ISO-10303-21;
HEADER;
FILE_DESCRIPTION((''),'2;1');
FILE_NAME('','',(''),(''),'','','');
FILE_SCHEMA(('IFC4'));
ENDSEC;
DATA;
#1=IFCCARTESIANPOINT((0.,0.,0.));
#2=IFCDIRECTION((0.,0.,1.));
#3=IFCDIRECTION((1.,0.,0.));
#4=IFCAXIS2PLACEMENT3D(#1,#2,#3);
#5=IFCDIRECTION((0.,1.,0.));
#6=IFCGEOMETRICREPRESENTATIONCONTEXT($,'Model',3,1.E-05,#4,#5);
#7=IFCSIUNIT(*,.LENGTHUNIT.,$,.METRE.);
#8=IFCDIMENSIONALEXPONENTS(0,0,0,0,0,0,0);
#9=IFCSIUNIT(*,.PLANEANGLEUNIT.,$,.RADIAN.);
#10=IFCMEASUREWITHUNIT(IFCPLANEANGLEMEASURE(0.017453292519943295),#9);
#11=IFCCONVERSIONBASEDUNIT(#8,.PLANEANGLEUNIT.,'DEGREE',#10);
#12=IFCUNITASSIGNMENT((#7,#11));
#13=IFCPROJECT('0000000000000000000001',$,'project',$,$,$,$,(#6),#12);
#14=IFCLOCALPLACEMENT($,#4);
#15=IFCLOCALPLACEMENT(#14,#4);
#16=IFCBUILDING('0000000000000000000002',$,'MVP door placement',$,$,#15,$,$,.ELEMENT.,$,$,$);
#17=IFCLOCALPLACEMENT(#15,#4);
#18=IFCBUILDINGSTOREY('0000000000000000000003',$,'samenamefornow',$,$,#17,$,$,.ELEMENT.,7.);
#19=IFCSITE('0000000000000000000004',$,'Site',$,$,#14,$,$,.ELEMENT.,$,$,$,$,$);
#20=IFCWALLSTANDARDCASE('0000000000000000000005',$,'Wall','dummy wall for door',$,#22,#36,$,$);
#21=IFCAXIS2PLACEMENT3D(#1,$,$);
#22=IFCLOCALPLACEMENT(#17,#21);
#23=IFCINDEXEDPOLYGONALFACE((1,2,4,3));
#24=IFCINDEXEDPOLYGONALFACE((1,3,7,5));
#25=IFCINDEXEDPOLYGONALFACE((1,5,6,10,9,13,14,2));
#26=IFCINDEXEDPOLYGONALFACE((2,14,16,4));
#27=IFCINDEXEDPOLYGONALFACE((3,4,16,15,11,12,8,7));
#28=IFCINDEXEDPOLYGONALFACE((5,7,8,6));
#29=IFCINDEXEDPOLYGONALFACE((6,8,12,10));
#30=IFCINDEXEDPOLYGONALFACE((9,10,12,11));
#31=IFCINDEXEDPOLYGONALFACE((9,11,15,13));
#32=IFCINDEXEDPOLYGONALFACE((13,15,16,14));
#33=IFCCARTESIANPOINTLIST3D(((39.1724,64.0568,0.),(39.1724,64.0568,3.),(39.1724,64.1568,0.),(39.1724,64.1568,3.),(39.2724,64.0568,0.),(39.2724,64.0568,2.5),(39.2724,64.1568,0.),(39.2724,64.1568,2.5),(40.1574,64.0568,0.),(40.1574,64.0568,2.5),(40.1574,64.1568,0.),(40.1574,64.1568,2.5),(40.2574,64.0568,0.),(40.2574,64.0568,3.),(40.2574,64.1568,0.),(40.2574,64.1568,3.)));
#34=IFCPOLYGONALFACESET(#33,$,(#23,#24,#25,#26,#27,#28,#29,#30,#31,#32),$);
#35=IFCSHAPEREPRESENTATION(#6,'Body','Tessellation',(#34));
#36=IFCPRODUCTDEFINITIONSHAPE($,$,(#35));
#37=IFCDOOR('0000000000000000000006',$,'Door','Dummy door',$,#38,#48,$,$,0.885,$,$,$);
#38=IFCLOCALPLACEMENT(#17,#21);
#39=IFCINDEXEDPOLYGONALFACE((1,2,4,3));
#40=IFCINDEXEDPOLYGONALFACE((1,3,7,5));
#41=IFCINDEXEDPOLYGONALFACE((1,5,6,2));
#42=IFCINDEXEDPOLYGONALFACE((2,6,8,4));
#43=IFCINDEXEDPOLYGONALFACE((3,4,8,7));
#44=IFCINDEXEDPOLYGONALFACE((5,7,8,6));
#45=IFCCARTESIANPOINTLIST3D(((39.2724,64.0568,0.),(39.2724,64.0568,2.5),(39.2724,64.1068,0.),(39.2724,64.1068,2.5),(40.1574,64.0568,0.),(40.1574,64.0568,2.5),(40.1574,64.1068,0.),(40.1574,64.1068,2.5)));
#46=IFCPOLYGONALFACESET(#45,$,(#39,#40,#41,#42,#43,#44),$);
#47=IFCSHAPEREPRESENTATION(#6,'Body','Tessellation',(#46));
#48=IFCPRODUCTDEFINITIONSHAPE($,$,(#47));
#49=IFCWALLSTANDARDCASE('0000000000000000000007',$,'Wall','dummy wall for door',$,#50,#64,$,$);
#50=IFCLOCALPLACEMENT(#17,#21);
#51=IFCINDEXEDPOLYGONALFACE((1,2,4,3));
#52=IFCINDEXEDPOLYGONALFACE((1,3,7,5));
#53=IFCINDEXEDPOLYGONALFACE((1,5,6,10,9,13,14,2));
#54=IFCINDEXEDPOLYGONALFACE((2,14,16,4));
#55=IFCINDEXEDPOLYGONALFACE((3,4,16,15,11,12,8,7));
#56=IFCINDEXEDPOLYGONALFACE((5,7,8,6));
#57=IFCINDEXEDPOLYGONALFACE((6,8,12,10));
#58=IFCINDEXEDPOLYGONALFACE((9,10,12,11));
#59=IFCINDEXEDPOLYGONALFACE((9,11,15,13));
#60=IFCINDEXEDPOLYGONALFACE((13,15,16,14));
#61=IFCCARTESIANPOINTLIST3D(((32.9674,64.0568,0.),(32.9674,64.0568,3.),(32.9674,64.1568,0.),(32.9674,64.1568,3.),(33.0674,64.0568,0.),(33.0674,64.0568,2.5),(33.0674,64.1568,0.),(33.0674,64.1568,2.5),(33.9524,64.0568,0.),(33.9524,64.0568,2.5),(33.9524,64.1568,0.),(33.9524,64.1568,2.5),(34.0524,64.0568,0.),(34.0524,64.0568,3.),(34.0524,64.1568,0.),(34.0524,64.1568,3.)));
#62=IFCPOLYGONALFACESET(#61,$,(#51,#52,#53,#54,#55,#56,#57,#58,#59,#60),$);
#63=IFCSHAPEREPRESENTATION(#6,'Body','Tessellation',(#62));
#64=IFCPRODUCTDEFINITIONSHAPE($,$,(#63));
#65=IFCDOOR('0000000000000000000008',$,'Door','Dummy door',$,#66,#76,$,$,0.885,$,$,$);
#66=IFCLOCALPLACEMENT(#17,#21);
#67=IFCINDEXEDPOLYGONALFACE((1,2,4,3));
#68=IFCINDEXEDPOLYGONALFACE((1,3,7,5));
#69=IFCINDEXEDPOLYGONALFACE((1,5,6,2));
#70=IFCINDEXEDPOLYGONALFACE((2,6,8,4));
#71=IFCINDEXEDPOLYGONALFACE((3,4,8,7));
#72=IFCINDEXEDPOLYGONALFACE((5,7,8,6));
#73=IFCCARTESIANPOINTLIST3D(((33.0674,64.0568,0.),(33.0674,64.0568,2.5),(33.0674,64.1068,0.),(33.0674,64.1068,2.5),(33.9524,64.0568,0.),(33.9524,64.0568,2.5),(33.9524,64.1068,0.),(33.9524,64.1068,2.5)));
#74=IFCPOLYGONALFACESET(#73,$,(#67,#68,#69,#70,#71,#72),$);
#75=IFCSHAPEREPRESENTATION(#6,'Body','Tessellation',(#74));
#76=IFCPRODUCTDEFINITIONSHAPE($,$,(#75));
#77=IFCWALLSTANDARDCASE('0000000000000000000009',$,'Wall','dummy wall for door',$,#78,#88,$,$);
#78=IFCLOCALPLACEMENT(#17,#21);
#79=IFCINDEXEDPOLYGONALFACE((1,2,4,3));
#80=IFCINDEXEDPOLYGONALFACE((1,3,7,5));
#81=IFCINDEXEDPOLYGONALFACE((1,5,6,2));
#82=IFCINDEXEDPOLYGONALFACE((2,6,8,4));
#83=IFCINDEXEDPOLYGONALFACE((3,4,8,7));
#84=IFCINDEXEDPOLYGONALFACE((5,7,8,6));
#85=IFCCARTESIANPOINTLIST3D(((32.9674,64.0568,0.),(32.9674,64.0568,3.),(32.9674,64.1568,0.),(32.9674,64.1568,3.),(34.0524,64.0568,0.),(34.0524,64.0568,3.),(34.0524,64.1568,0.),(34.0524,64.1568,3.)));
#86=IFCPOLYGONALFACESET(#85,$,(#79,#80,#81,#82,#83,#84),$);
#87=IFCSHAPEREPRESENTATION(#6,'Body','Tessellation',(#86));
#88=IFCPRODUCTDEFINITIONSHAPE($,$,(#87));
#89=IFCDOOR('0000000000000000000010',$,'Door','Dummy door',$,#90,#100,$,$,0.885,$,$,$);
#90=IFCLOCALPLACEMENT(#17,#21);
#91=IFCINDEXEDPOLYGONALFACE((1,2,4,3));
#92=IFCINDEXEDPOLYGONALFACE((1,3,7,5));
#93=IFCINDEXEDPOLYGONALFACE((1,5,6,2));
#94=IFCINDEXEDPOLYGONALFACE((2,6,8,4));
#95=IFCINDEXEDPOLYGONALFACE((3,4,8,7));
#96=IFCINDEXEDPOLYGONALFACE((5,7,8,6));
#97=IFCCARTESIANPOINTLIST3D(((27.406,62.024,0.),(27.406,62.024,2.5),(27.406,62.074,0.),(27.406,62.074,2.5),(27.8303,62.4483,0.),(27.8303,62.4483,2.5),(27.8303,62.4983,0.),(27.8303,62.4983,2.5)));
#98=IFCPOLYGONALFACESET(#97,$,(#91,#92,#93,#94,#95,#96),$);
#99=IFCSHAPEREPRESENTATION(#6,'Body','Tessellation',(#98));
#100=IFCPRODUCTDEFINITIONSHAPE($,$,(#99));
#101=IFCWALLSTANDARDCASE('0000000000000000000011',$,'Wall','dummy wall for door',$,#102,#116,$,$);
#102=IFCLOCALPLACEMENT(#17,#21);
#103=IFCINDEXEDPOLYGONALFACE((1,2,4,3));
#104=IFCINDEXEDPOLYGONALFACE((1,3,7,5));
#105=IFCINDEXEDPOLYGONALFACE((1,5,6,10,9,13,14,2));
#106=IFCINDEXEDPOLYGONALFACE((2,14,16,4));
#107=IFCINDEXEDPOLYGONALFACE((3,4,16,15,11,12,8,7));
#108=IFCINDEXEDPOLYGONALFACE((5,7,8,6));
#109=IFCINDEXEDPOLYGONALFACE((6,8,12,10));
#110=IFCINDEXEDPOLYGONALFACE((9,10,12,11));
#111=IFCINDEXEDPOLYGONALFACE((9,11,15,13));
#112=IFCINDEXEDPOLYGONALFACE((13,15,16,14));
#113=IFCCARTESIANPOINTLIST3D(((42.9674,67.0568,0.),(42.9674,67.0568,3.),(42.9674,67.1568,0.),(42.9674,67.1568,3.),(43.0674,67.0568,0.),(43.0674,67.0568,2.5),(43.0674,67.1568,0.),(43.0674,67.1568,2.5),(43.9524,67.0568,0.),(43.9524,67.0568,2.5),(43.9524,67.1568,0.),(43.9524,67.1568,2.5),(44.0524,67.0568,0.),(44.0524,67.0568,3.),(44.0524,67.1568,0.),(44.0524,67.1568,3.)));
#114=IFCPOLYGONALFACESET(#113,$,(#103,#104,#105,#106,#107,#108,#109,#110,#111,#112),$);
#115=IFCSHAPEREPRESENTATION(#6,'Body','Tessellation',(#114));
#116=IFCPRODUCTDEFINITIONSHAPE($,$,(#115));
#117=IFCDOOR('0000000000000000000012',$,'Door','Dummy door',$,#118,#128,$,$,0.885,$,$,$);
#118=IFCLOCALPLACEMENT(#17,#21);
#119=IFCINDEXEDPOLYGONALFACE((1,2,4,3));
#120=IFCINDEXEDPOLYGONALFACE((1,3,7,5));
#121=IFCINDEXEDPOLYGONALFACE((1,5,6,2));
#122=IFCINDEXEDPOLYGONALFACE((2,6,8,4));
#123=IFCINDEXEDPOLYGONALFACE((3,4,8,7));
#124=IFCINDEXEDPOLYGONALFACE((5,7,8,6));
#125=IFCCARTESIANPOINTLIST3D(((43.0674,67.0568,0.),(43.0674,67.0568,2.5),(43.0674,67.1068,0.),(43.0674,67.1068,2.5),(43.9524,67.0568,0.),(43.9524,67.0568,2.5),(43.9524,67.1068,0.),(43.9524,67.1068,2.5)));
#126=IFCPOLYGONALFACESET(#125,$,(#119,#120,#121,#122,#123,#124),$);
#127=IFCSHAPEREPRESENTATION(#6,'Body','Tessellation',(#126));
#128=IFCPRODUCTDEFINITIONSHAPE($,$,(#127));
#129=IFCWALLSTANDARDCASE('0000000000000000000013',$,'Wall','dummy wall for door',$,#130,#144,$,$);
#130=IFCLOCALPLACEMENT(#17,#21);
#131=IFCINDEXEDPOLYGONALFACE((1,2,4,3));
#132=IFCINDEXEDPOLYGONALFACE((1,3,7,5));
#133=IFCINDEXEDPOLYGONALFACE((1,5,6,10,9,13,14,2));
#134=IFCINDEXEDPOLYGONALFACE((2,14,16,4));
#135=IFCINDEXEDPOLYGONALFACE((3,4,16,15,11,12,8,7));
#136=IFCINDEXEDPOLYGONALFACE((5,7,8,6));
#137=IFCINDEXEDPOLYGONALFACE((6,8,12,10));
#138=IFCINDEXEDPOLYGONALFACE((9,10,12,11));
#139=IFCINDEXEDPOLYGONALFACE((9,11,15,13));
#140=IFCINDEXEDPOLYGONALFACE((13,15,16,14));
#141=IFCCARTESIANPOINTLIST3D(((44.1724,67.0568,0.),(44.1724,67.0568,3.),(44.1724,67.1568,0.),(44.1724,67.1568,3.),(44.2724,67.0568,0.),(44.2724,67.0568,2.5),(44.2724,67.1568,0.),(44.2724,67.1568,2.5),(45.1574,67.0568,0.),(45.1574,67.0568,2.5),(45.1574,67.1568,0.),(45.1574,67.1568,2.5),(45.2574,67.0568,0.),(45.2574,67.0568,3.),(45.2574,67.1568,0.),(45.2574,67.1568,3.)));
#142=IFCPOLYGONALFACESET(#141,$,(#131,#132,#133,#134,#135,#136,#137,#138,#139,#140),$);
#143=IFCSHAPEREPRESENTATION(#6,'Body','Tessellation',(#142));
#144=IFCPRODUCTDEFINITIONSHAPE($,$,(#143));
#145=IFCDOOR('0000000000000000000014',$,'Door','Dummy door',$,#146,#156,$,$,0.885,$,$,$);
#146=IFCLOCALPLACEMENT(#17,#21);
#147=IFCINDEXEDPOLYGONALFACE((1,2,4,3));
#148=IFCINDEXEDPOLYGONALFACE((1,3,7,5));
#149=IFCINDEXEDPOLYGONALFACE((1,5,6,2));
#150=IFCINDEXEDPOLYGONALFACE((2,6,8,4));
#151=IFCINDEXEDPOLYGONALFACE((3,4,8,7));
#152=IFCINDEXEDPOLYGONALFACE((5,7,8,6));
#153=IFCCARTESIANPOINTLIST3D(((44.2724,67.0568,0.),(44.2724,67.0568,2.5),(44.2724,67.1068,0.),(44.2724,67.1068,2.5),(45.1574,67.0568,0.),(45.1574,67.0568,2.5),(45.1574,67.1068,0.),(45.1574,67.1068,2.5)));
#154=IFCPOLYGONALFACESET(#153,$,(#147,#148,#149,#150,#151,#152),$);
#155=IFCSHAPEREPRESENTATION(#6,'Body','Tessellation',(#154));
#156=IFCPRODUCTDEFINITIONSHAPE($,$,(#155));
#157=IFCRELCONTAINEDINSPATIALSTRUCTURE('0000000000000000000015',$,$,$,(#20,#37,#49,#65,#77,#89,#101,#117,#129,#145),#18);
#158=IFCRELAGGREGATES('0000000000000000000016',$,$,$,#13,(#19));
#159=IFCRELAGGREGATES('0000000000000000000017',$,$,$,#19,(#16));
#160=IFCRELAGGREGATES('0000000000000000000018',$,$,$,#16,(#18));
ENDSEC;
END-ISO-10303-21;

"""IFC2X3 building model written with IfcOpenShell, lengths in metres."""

from ifc_helpers import new_model, entity, si_unit, converted_unit, direction, origin_with_axes, place, context, project, spatial, polyline, outline, extrude, element, fill, save


model = new_model("IFC2X3")

# Units and contexts
model_context = context("Model", 3, precision=1e-05, world=origin_with_axes(), true_north=direction((0.0, 1.0, 0.0)))
ifc_project = project(units=[si_unit("LENGTHUNIT", "METRE"), converted_unit("PLANEANGLEUNIT", "DEGREE", entity("IfcPlaneAngleMeasure", 0.017453292519943295), si_unit("PLANEANGLEUNIT", "RADIAN"), dimensions=[0, 0, 0, 0, 0, 0, 0])], contexts=[model_context])

# Site, building, storey
site_placement = place(None, origin_with_axes())
site = spatial("IfcSite", under=ifc_project, at=site_placement, Name="Site", CompositionType="ELEMENT")
building_placement = place(site_placement, origin_with_axes())
building = spatial("IfcBuilding", under=site, at=building_placement, Name="MVP door placement", CompositionType="ELEMENT")
storey_placement = place(building_placement, origin_with_axes())
storey = spatial("IfcBuildingStorey", under=building, at=storey_placement, Name="samenamefornow", CompositionType="ELEMENT", Elevation=7.0)

# Walls, openings, doors
wall_1_placement = place(storey_placement, origin_with_axes())
wall_1 = element("IfcWallStandardCase", 1, at=wall_1_placement, inside=storey, Name="Wall", Description="dummy wall for door", context=model_context, shape_type="SweptSolid", body=[
    extrude(outline(polyline([(40.2574, 64.0568, 0.0), (39.1724, 64.0568, 0.0), (39.1724, 64.1568, 0.0), (40.2574, 64.1568, 0.0), (40.2574, 64.0568, 0.0)])), origin_with_axes(), (0.0, 0.0, 1.0), 3.0),
])
opening_1_placement = place(wall_1_placement, origin_with_axes())
opening_1 = element("IfcOpeningElement", 2, at=opening_1_placement, cuts=wall_1, context=model_context, shape_type="SweptSolid", body=[
    extrude(outline(polyline([(40.1574, 64.0568, 0.0), (39.2724, 64.0568, 0.0), (39.2724, 64.1568, 0.0), (40.1574, 64.1568, 0.0), (40.1574, 64.0568, 0.0)])), origin_with_axes(), (0.0, 0.0, 1.0), 2.5),
])
door_1_placement = place(opening_1_placement, origin_with_axes())
door_1 = element("IfcDoor", 3, at=door_1_placement, inside=storey, Name="Door", Description="Dummy door", OverallWidth=0.885, context=model_context, shape_type="SweptSolid", body=[
    extrude(outline(polyline([(40.1574, 64.0568, 0.0), (39.2724, 64.0568, 0.0), (39.2724, 64.1068, 0.0), (40.1574, 64.1068, 0.0), (40.1574, 64.0568, 0.0)])), origin_with_axes(), (0.0, 0.0, 1.0), 2.5),
])
fill(opening_1, door_1)
wall_2_placement = place(storey_placement, origin_with_axes())
wall_2 = element("IfcWallStandardCase", 4, at=wall_2_placement, inside=storey, Name="Wall", Description="dummy wall for door", context=model_context, shape_type="SweptSolid", body=[
    extrude(outline(polyline([(32.9674, 64.0568, 0.0), (34.0524, 64.0568, 0.0), (34.0524, 64.1568, 0.0), (32.9674, 64.1568, 0.0), (32.9674, 64.0568, 0.0)])), origin_with_axes(), (0.0, 0.0, 1.0), 3.0),
])
opening_2_placement = place(wall_2_placement, origin_with_axes())
opening_2 = element("IfcOpeningElement", 5, at=opening_2_placement, cuts=wall_2, context=model_context, shape_type="SweptSolid", body=[
    extrude(outline(polyline([(33.0674, 64.0568, 0.0), (33.9524, 64.0568, 0.0), (33.9524, 64.1568, 0.0), (33.0674, 64.1568, 0.0), (33.0674, 64.0568, 0.0)])), origin_with_axes(), (0.0, 0.0, 1.0), 2.5),
])
door_2_placement = place(opening_2_placement, origin_with_axes())
door_2 = element("IfcDoor", 6, at=door_2_placement, inside=storey, Name="Door", Description="Dummy door", OverallWidth=0.885, context=model_context, shape_type="SweptSolid", body=[
    extrude(outline(polyline([(33.0674, 64.0568, 0.0), (33.9524, 64.0568, 0.0), (33.9524, 64.1068, 0.0), (33.0674, 64.1068, 0.0), (33.0674, 64.0568, 0.0)])), origin_with_axes(), (0.0, 0.0, 1.0), 2.5),
])
fill(opening_2, door_2)
wall_3_placement = place(storey_placement, origin_with_axes())
wall_3 = element("IfcWallStandardCase", 7, at=wall_3_placement, inside=storey, Name="Wall", Description="dummy wall for door", context=model_context, shape_type="SweptSolid", body=[
    extrude(outline(polyline([(32.9674, 64.0568, 0.0), (34.0524, 64.0568, 0.0), (34.0524, 64.1568, 0.0), (32.9674, 64.1568, 0.0), (32.9674, 64.0568, 0.0)])), origin_with_axes(), (0.0, 0.0, 1.0), 3.0),
])
opening_3_placement = place(wall_3_placement, origin_with_axes())
opening_3 = element("IfcOpeningElement", 8, at=opening_3_placement, cuts=wall_3, context=model_context, shape_type="SweptSolid", body=[
    extrude(outline(polyline([(27.406, 62.024, 0.0), (27.8303, 62.4483, 0.0), (27.8303, 62.5483, 0.0), (27.406, 62.124, 0.0), (27.406, 62.024, 0.0)])), origin_with_axes(), (0.0, 0.0, 1.0), 2.5),
])
door_3_placement = place(opening_3_placement, origin_with_axes())
door_3 = element("IfcDoor", 9, at=door_3_placement, inside=storey, Name="Door", Description="Dummy door", OverallWidth=0.885, context=model_context, shape_type="SweptSolid", body=[
    extrude(outline(polyline([(27.406, 62.024, 0.0), (27.8303, 62.4483, 0.0), (27.8303, 62.4983, 0.0), (27.406, 62.074, 0.0), (27.406, 62.024, 0.0)])), origin_with_axes(), (0.0, 0.0, 1.0), 2.5),
])
fill(opening_3, door_3)
wall_4_placement = place(storey_placement, origin_with_axes())
wall_4 = element("IfcWallStandardCase", 10, at=wall_4_placement, inside=storey, Name="Wall", Description="dummy wall for door", context=model_context, shape_type="SweptSolid", body=[
    extrude(outline(polyline([(42.9674, 67.0568, 0.0), (44.0524, 67.0568, 0.0), (44.0524, 67.1568, 0.0), (42.9674, 67.1568, 0.0), (42.9674, 67.0568, 0.0)])), origin_with_axes(), (0.0, 0.0, 1.0), 3.0),
])
opening_4_placement = place(wall_4_placement, origin_with_axes())
opening_4 = element("IfcOpeningElement", 11, at=opening_4_placement, cuts=wall_4, context=model_context, shape_type="SweptSolid", body=[
    extrude(outline(polyline([(43.0674, 67.0568, 0.0), (43.9524, 67.0568, 0.0), (43.9524, 67.1568, 0.0), (43.0674, 67.1568, 0.0), (43.0674, 67.0568, 0.0)])), origin_with_axes(), (0.0, 0.0, 1.0), 2.5),
])
door_4_placement = place(opening_4_placement, origin_with_axes())
door_4 = element("IfcDoor", 12, at=door_4_placement, inside=storey, Name="Door", Description="Dummy door", OverallWidth=0.885, context=model_context, shape_type="SweptSolid", body=[
    extrude(outline(polyline([(43.0674, 67.0568, 0.0), (43.9524, 67.0568, 0.0), (43.9524, 67.1068, 0.0), (43.0674, 67.1068, 0.0), (43.0674, 67.0568, 0.0)])), origin_with_axes(), (0.0, 0.0, 1.0), 2.5),
])
fill(opening_4, door_4)
wall_5_placement = place(storey_placement, origin_with_axes())
wall_5 = element("IfcWallStandardCase", 13, at=wall_5_placement, inside=storey, Name="Wall", Description="dummy wall for door", context=model_context, shape_type="SweptSolid", body=[
    extrude(outline(polyline([(45.2574, 67.0568, 0.0), (44.1724, 67.0568, 0.0), (44.1724, 67.1568, 0.0), (45.2574, 67.1568, 0.0), (45.2574, 67.0568, 0.0)])), origin_with_axes(), (0.0, 0.0, 1.0), 3.0),
])
opening_5_placement = place(wall_5_placement, origin_with_axes())
opening_5 = element("IfcOpeningElement", 14, at=opening_5_placement, cuts=wall_5, context=model_context, shape_type="SweptSolid", body=[
    extrude(outline(polyline([(45.1574, 67.0568, 0.0), (44.2724, 67.0568, 0.0), (44.2724, 67.1568, 0.0), (45.1574, 67.1568, 0.0), (45.1574, 67.0568, 0.0)])), origin_with_axes(), (0.0, 0.0, 1.0), 2.5),
])
door_5_placement = place(opening_5_placement, origin_with_axes())
door_5 = element("IfcDoor", 15, at=door_5_placement, inside=storey, Name="Door", Description="Dummy door", OverallWidth=0.885, context=model_context, shape_type="SweptSolid", body=[
    extrude(outline(polyline([(45.1574, 67.0568, 0.0), (44.2724, 67.0568, 0.0), (44.2724, 67.1068, 0.0), (45.1574, 67.1068, 0.0), (45.1574, 67.0568, 0.0)])), origin_with_axes(), (0.0, 0.0, 1.0), 2.5),
])
fill(opening_5, door_5)

save(model, "model.ifc")
